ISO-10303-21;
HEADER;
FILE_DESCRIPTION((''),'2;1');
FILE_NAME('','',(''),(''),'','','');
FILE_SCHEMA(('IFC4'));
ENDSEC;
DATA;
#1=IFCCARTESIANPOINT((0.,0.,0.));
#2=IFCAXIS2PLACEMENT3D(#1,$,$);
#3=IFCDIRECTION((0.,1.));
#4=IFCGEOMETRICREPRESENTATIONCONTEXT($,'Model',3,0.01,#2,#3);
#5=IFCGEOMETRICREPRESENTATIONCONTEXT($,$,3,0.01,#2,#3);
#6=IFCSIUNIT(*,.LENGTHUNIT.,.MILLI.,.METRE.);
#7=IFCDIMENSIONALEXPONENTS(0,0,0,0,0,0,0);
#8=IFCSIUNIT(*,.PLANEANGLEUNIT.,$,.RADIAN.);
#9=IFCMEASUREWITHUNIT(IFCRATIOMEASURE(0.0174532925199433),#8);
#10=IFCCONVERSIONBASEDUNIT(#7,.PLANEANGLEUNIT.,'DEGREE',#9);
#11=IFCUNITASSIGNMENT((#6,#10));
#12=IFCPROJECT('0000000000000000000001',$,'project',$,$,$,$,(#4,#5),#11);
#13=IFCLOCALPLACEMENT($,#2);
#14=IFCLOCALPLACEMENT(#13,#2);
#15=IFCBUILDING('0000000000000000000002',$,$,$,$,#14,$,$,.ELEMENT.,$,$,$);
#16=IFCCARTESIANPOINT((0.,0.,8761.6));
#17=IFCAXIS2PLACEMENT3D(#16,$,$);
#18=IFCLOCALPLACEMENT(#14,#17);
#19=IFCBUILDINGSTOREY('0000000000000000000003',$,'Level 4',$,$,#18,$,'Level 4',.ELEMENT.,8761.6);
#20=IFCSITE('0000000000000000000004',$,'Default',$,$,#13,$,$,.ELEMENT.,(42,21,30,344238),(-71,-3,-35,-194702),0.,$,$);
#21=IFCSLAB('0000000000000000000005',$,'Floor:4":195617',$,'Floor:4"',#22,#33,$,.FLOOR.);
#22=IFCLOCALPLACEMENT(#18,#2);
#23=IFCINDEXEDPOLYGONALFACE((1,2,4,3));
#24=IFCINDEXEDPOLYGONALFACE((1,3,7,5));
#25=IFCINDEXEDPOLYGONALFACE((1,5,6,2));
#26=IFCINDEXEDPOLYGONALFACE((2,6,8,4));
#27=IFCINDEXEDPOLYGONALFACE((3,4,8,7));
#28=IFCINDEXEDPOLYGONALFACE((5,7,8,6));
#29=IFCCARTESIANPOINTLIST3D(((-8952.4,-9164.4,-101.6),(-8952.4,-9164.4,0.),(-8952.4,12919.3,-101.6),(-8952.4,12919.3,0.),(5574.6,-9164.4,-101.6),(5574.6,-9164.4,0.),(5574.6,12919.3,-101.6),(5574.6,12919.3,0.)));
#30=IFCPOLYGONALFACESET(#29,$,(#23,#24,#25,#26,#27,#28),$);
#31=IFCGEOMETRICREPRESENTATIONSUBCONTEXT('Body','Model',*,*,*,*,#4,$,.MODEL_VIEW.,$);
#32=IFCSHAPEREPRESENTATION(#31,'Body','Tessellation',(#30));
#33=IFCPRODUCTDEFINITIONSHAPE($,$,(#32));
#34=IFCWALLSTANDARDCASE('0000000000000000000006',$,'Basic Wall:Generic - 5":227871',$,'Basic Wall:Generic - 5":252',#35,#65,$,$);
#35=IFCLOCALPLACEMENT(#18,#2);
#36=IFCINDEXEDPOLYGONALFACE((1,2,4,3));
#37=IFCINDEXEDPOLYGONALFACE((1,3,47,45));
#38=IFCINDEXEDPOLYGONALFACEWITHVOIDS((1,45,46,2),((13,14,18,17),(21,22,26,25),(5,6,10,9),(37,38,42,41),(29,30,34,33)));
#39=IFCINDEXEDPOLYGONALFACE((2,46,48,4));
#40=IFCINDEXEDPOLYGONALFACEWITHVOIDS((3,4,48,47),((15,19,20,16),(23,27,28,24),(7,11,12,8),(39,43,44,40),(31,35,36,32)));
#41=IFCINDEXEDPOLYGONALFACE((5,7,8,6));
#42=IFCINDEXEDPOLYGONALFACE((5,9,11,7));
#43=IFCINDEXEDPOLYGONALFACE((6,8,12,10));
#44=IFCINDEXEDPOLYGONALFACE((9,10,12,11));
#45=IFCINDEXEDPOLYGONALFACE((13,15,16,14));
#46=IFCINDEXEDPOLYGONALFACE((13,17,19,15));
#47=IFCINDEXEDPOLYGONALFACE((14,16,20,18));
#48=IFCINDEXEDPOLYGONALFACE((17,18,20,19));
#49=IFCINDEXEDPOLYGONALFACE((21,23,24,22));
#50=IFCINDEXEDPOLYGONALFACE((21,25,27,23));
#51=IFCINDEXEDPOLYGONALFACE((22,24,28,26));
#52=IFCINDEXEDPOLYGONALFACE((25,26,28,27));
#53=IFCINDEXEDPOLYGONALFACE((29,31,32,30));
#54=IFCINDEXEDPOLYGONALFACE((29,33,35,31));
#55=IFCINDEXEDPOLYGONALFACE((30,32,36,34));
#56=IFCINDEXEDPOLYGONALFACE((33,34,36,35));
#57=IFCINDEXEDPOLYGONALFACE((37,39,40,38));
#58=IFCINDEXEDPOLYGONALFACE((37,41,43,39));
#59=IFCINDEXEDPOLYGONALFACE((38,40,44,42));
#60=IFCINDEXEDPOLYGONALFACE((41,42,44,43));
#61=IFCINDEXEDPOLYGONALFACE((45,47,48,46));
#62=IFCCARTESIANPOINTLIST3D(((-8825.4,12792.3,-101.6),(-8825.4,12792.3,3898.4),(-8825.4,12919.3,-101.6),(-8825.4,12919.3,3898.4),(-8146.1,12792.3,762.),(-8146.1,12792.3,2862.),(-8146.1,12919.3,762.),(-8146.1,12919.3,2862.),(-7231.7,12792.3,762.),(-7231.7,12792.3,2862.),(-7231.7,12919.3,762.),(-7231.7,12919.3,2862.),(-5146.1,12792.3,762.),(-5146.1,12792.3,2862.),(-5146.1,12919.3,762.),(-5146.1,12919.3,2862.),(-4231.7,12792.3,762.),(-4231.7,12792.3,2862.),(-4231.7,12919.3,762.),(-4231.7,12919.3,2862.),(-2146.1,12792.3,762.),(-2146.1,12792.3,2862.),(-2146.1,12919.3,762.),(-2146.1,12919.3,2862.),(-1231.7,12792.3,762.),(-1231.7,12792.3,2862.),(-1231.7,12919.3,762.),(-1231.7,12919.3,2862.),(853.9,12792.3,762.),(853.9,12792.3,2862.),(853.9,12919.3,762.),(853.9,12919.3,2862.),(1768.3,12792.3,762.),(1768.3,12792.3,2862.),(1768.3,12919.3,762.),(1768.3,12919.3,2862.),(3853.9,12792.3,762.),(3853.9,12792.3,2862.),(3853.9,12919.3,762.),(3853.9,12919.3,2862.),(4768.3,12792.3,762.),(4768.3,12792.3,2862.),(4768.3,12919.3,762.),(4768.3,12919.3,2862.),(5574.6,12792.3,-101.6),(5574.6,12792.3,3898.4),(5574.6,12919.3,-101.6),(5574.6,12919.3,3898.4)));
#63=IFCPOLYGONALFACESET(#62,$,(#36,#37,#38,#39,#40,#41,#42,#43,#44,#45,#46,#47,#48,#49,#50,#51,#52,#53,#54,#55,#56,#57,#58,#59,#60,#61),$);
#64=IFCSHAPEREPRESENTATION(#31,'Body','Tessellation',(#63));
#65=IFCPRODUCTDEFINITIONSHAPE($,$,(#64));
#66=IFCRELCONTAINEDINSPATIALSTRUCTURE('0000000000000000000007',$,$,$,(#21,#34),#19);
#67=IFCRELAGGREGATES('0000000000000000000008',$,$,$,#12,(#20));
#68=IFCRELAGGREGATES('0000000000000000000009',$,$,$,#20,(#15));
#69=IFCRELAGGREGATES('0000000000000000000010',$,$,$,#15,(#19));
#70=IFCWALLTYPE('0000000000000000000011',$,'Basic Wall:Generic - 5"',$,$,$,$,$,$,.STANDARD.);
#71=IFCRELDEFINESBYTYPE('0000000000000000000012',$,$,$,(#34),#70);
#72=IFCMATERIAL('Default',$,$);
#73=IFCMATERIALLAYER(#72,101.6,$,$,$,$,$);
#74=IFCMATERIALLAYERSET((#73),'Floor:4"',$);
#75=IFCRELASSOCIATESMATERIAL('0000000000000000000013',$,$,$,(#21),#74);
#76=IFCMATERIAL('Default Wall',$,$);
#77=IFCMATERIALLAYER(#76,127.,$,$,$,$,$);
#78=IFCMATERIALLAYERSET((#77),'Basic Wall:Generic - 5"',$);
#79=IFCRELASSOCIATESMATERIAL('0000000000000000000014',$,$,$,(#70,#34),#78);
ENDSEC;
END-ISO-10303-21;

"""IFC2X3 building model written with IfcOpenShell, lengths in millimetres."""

from ifc_helpers import new_model, entity, si_unit, converted_unit, direction, frame, frame_2d, origin, place, context, subcontext, project, spatial, polyline, rectangle, extrude, clip, bounded_halfspace, material, layer, layer_set, layer_usage, type_object, element, save


model = new_model("IFC2X3")

# Units and contexts
model_context = context("Model", 3, precision=0.01, world=origin(), true_north=direction((0.0, 1.0)))
context_of_model = context(None, 3, precision=0.01, world=origin(), true_north=direction((0.0, 1.0)))
body_context = subcontext(model_context, "Body", "Model", "MODEL_VIEW")
ifc_project = project(units=[si_unit("LENGTHUNIT", "METRE", prefix="MILLI"), converted_unit("PLANEANGLEUNIT", "DEGREE", entity("IfcRatioMeasure", 0.0174532925199433), si_unit("PLANEANGLEUNIT", "RADIAN"), dimensions=[0, 0, 0, 0, 0, 0, 0])], contexts=[model_context, context_of_model])

# Site, building, storey
site_placement = place(None, origin())
site = spatial("IfcSite", under=ifc_project, at=site_placement, Name="Default", CompositionType="ELEMENT", RefLatitude=(42, 21, 30, 344238), RefLongitude=(-71, -3, -35, -194702), RefElevation=0.0)
building_placement = place(site_placement, origin())
building = spatial("IfcBuilding", under=site, at=building_placement, CompositionType="ELEMENT")
storey_placement = place(building_placement, frame((0.0, 0.0, 8761.6)))
storey = spatial("IfcBuildingStorey", under=building, at=storey_placement, Name="Level 4", LongName="Level 4", CompositionType="ELEMENT", Elevation=8761.6)

# Slab
ifc_material_1 = material(Name="Default")
ifc_layer_1 = layer(ifc_material_1, 101.6)
ifc_layer_set_1 = layer_set([ifc_layer_1], Name="Floor:4\"")
ifc_layer_usage_1 = layer_usage(ifc_layer_set_1, "AXIS3", "POSITIVE", 0.0)
slab_placement = place(storey_placement, origin())
element("IfcSlab", 1, at=slab_placement, inside=storey, material=ifc_layer_usage_1, Name="Floor:4\":195617", ObjectType="Floor:4\"", PredefinedType="FLOOR", context=body_context, shape_type="SweptSolid", body=[
    extrude(rectangle(XDim=22083.7, YDim=14527.0, at=frame_2d((0.0, 0.0), x_axis=(1.0, 0.0))), frame((-1688.9, 1877.4, 0.0), z_axis=(0.0, 0.0, -1.0), x_axis=(0.0, 1.0, 0.0)), (0.0, 0.0, 1.0), 101.6),
])

# Wall, openings
ifc_material_2 = material(Name="Default Wall")
ifc_layer_2 = layer(ifc_material_2, 127.0)
ifc_layer_set_2 = layer_set([ifc_layer_2], Name="Basic Wall:Generic - 5\"")
ifc_layer_usage_2 = layer_usage(ifc_layer_set_2, "AXIS2", "NEGATIVE", 63.5)
wall_type = type_object("IfcWallType", Name="Basic Wall:Generic - 5\"", PredefinedType="STANDARD", material=ifc_layer_set_2)
wall_1_placement = place(storey_placement, frame((-8825.4, 12855.8, -101.6)))
wall_1 = element("IfcWallStandardCase", 2, at=wall_1_placement, inside=storey, type_object=wall_type, material=ifc_layer_usage_2, Name="Basic Wall:Generic - 5\":227871", ObjectType="Basic Wall:Generic - 5\":252", context=body_context, shape_type="Clipping", body=[
    clip(extrude(rectangle(XDim=14400.0, YDim=127.0, at=frame_2d((7200.0, 0.0), x_axis=(-1.0, 0.0))), origin(), (0.0, 0.0, 1.0), 4000.0), bounded_halfspace(frame((0.0, -63.5, 4000.0), z_axis=(0.0, 0.0, -1.0), x_axis=(0.0, -1.0, 0.0)), True, frame((0.0, -63.5, 4000.0)), polyline([(0.0, 0.0), (14273.0, 0.0), (14400.0, 0.0), (14400.0, 127.0), (0.0, 127.0), (0.0, 0.0)]))),
])
opening_1_placement = place(wall_1_placement, frame((679.3, -63.5, 863.6)))
element("IfcOpeningElement", 3, at=opening_1_placement, cuts=wall_1, ObjectType="Opening", context=body_context, shape_type="SweptSolid", body=[
    extrude(rectangle(XDim=2100.0, YDim=914.4, at=frame_2d((1050.0, 457.2), x_axis=(-1.0, 0.0))), frame((0.0, 0.0, 0.0), z_axis=(0.0, 1.0, 0.0), x_axis=(0.0, 0.0, 1.0)), (0.0, 0.0, 1.0), 127.0),
])
opening_2_placement = place(wall_1_placement, frame((3679.3, -63.5, 863.6)))
element("IfcOpeningElement", 4, at=opening_2_placement, cuts=wall_1, ObjectType="Opening", context=body_context, shape_type="SweptSolid", body=[
    extrude(rectangle(XDim=2100.0, YDim=914.4, at=frame_2d((1050.0, 457.2), x_axis=(-1.0, 0.0))), frame((0.0, 0.0, 0.0), z_axis=(0.0, 1.0, 0.0), x_axis=(0.0, 0.0, 1.0)), (0.0, 0.0, 1.0), 127.0),
])
opening_3_placement = place(wall_1_placement, frame((6679.3, -63.5, 863.6)))
element("IfcOpeningElement", 5, at=opening_3_placement, cuts=wall_1, ObjectType="Opening", context=body_context, shape_type="SweptSolid", body=[
    extrude(rectangle(XDim=2100.0, YDim=914.4, at=frame_2d((1050.0, 457.2), x_axis=(-1.0, 0.0))), frame((0.0, 0.0, 0.0), z_axis=(0.0, 1.0, 0.0), x_axis=(0.0, 0.0, 1.0)), (0.0, 0.0, 1.0), 127.0),
])
opening_4_placement = place(wall_1_placement, frame((9679.3, -63.5, 863.6)))
element("IfcOpeningElement", 6, at=opening_4_placement, cuts=wall_1, ObjectType="Opening", context=body_context, shape_type="SweptSolid", body=[
    extrude(rectangle(XDim=2100.0, YDim=914.4, at=frame_2d((1050.0, 457.2), x_axis=(-1.0, 0.0))), frame((0.0, 0.0, 0.0), z_axis=(0.0, 1.0, 0.0), x_axis=(0.0, 0.0, 1.0)), (0.0, 0.0, 1.0), 127.0),
])
opening_5_placement = place(wall_1_placement, frame((12679.3, -63.5, 863.6)))
element("IfcOpeningElement", 7, at=opening_5_placement, cuts=wall_1, ObjectType="Opening", context=body_context, shape_type="SweptSolid", body=[
    extrude(rectangle(XDim=2100.0, YDim=914.4, at=frame_2d((1050.0, 457.2), x_axis=(-1.0, 0.0))), frame((0.0, 0.0, 0.0), z_axis=(0.0, 1.0, 0.0), x_axis=(0.0, 0.0, 1.0)), (0.0, 0.0, 1.0), 127.0),
])

save(model, "model.ifc")
